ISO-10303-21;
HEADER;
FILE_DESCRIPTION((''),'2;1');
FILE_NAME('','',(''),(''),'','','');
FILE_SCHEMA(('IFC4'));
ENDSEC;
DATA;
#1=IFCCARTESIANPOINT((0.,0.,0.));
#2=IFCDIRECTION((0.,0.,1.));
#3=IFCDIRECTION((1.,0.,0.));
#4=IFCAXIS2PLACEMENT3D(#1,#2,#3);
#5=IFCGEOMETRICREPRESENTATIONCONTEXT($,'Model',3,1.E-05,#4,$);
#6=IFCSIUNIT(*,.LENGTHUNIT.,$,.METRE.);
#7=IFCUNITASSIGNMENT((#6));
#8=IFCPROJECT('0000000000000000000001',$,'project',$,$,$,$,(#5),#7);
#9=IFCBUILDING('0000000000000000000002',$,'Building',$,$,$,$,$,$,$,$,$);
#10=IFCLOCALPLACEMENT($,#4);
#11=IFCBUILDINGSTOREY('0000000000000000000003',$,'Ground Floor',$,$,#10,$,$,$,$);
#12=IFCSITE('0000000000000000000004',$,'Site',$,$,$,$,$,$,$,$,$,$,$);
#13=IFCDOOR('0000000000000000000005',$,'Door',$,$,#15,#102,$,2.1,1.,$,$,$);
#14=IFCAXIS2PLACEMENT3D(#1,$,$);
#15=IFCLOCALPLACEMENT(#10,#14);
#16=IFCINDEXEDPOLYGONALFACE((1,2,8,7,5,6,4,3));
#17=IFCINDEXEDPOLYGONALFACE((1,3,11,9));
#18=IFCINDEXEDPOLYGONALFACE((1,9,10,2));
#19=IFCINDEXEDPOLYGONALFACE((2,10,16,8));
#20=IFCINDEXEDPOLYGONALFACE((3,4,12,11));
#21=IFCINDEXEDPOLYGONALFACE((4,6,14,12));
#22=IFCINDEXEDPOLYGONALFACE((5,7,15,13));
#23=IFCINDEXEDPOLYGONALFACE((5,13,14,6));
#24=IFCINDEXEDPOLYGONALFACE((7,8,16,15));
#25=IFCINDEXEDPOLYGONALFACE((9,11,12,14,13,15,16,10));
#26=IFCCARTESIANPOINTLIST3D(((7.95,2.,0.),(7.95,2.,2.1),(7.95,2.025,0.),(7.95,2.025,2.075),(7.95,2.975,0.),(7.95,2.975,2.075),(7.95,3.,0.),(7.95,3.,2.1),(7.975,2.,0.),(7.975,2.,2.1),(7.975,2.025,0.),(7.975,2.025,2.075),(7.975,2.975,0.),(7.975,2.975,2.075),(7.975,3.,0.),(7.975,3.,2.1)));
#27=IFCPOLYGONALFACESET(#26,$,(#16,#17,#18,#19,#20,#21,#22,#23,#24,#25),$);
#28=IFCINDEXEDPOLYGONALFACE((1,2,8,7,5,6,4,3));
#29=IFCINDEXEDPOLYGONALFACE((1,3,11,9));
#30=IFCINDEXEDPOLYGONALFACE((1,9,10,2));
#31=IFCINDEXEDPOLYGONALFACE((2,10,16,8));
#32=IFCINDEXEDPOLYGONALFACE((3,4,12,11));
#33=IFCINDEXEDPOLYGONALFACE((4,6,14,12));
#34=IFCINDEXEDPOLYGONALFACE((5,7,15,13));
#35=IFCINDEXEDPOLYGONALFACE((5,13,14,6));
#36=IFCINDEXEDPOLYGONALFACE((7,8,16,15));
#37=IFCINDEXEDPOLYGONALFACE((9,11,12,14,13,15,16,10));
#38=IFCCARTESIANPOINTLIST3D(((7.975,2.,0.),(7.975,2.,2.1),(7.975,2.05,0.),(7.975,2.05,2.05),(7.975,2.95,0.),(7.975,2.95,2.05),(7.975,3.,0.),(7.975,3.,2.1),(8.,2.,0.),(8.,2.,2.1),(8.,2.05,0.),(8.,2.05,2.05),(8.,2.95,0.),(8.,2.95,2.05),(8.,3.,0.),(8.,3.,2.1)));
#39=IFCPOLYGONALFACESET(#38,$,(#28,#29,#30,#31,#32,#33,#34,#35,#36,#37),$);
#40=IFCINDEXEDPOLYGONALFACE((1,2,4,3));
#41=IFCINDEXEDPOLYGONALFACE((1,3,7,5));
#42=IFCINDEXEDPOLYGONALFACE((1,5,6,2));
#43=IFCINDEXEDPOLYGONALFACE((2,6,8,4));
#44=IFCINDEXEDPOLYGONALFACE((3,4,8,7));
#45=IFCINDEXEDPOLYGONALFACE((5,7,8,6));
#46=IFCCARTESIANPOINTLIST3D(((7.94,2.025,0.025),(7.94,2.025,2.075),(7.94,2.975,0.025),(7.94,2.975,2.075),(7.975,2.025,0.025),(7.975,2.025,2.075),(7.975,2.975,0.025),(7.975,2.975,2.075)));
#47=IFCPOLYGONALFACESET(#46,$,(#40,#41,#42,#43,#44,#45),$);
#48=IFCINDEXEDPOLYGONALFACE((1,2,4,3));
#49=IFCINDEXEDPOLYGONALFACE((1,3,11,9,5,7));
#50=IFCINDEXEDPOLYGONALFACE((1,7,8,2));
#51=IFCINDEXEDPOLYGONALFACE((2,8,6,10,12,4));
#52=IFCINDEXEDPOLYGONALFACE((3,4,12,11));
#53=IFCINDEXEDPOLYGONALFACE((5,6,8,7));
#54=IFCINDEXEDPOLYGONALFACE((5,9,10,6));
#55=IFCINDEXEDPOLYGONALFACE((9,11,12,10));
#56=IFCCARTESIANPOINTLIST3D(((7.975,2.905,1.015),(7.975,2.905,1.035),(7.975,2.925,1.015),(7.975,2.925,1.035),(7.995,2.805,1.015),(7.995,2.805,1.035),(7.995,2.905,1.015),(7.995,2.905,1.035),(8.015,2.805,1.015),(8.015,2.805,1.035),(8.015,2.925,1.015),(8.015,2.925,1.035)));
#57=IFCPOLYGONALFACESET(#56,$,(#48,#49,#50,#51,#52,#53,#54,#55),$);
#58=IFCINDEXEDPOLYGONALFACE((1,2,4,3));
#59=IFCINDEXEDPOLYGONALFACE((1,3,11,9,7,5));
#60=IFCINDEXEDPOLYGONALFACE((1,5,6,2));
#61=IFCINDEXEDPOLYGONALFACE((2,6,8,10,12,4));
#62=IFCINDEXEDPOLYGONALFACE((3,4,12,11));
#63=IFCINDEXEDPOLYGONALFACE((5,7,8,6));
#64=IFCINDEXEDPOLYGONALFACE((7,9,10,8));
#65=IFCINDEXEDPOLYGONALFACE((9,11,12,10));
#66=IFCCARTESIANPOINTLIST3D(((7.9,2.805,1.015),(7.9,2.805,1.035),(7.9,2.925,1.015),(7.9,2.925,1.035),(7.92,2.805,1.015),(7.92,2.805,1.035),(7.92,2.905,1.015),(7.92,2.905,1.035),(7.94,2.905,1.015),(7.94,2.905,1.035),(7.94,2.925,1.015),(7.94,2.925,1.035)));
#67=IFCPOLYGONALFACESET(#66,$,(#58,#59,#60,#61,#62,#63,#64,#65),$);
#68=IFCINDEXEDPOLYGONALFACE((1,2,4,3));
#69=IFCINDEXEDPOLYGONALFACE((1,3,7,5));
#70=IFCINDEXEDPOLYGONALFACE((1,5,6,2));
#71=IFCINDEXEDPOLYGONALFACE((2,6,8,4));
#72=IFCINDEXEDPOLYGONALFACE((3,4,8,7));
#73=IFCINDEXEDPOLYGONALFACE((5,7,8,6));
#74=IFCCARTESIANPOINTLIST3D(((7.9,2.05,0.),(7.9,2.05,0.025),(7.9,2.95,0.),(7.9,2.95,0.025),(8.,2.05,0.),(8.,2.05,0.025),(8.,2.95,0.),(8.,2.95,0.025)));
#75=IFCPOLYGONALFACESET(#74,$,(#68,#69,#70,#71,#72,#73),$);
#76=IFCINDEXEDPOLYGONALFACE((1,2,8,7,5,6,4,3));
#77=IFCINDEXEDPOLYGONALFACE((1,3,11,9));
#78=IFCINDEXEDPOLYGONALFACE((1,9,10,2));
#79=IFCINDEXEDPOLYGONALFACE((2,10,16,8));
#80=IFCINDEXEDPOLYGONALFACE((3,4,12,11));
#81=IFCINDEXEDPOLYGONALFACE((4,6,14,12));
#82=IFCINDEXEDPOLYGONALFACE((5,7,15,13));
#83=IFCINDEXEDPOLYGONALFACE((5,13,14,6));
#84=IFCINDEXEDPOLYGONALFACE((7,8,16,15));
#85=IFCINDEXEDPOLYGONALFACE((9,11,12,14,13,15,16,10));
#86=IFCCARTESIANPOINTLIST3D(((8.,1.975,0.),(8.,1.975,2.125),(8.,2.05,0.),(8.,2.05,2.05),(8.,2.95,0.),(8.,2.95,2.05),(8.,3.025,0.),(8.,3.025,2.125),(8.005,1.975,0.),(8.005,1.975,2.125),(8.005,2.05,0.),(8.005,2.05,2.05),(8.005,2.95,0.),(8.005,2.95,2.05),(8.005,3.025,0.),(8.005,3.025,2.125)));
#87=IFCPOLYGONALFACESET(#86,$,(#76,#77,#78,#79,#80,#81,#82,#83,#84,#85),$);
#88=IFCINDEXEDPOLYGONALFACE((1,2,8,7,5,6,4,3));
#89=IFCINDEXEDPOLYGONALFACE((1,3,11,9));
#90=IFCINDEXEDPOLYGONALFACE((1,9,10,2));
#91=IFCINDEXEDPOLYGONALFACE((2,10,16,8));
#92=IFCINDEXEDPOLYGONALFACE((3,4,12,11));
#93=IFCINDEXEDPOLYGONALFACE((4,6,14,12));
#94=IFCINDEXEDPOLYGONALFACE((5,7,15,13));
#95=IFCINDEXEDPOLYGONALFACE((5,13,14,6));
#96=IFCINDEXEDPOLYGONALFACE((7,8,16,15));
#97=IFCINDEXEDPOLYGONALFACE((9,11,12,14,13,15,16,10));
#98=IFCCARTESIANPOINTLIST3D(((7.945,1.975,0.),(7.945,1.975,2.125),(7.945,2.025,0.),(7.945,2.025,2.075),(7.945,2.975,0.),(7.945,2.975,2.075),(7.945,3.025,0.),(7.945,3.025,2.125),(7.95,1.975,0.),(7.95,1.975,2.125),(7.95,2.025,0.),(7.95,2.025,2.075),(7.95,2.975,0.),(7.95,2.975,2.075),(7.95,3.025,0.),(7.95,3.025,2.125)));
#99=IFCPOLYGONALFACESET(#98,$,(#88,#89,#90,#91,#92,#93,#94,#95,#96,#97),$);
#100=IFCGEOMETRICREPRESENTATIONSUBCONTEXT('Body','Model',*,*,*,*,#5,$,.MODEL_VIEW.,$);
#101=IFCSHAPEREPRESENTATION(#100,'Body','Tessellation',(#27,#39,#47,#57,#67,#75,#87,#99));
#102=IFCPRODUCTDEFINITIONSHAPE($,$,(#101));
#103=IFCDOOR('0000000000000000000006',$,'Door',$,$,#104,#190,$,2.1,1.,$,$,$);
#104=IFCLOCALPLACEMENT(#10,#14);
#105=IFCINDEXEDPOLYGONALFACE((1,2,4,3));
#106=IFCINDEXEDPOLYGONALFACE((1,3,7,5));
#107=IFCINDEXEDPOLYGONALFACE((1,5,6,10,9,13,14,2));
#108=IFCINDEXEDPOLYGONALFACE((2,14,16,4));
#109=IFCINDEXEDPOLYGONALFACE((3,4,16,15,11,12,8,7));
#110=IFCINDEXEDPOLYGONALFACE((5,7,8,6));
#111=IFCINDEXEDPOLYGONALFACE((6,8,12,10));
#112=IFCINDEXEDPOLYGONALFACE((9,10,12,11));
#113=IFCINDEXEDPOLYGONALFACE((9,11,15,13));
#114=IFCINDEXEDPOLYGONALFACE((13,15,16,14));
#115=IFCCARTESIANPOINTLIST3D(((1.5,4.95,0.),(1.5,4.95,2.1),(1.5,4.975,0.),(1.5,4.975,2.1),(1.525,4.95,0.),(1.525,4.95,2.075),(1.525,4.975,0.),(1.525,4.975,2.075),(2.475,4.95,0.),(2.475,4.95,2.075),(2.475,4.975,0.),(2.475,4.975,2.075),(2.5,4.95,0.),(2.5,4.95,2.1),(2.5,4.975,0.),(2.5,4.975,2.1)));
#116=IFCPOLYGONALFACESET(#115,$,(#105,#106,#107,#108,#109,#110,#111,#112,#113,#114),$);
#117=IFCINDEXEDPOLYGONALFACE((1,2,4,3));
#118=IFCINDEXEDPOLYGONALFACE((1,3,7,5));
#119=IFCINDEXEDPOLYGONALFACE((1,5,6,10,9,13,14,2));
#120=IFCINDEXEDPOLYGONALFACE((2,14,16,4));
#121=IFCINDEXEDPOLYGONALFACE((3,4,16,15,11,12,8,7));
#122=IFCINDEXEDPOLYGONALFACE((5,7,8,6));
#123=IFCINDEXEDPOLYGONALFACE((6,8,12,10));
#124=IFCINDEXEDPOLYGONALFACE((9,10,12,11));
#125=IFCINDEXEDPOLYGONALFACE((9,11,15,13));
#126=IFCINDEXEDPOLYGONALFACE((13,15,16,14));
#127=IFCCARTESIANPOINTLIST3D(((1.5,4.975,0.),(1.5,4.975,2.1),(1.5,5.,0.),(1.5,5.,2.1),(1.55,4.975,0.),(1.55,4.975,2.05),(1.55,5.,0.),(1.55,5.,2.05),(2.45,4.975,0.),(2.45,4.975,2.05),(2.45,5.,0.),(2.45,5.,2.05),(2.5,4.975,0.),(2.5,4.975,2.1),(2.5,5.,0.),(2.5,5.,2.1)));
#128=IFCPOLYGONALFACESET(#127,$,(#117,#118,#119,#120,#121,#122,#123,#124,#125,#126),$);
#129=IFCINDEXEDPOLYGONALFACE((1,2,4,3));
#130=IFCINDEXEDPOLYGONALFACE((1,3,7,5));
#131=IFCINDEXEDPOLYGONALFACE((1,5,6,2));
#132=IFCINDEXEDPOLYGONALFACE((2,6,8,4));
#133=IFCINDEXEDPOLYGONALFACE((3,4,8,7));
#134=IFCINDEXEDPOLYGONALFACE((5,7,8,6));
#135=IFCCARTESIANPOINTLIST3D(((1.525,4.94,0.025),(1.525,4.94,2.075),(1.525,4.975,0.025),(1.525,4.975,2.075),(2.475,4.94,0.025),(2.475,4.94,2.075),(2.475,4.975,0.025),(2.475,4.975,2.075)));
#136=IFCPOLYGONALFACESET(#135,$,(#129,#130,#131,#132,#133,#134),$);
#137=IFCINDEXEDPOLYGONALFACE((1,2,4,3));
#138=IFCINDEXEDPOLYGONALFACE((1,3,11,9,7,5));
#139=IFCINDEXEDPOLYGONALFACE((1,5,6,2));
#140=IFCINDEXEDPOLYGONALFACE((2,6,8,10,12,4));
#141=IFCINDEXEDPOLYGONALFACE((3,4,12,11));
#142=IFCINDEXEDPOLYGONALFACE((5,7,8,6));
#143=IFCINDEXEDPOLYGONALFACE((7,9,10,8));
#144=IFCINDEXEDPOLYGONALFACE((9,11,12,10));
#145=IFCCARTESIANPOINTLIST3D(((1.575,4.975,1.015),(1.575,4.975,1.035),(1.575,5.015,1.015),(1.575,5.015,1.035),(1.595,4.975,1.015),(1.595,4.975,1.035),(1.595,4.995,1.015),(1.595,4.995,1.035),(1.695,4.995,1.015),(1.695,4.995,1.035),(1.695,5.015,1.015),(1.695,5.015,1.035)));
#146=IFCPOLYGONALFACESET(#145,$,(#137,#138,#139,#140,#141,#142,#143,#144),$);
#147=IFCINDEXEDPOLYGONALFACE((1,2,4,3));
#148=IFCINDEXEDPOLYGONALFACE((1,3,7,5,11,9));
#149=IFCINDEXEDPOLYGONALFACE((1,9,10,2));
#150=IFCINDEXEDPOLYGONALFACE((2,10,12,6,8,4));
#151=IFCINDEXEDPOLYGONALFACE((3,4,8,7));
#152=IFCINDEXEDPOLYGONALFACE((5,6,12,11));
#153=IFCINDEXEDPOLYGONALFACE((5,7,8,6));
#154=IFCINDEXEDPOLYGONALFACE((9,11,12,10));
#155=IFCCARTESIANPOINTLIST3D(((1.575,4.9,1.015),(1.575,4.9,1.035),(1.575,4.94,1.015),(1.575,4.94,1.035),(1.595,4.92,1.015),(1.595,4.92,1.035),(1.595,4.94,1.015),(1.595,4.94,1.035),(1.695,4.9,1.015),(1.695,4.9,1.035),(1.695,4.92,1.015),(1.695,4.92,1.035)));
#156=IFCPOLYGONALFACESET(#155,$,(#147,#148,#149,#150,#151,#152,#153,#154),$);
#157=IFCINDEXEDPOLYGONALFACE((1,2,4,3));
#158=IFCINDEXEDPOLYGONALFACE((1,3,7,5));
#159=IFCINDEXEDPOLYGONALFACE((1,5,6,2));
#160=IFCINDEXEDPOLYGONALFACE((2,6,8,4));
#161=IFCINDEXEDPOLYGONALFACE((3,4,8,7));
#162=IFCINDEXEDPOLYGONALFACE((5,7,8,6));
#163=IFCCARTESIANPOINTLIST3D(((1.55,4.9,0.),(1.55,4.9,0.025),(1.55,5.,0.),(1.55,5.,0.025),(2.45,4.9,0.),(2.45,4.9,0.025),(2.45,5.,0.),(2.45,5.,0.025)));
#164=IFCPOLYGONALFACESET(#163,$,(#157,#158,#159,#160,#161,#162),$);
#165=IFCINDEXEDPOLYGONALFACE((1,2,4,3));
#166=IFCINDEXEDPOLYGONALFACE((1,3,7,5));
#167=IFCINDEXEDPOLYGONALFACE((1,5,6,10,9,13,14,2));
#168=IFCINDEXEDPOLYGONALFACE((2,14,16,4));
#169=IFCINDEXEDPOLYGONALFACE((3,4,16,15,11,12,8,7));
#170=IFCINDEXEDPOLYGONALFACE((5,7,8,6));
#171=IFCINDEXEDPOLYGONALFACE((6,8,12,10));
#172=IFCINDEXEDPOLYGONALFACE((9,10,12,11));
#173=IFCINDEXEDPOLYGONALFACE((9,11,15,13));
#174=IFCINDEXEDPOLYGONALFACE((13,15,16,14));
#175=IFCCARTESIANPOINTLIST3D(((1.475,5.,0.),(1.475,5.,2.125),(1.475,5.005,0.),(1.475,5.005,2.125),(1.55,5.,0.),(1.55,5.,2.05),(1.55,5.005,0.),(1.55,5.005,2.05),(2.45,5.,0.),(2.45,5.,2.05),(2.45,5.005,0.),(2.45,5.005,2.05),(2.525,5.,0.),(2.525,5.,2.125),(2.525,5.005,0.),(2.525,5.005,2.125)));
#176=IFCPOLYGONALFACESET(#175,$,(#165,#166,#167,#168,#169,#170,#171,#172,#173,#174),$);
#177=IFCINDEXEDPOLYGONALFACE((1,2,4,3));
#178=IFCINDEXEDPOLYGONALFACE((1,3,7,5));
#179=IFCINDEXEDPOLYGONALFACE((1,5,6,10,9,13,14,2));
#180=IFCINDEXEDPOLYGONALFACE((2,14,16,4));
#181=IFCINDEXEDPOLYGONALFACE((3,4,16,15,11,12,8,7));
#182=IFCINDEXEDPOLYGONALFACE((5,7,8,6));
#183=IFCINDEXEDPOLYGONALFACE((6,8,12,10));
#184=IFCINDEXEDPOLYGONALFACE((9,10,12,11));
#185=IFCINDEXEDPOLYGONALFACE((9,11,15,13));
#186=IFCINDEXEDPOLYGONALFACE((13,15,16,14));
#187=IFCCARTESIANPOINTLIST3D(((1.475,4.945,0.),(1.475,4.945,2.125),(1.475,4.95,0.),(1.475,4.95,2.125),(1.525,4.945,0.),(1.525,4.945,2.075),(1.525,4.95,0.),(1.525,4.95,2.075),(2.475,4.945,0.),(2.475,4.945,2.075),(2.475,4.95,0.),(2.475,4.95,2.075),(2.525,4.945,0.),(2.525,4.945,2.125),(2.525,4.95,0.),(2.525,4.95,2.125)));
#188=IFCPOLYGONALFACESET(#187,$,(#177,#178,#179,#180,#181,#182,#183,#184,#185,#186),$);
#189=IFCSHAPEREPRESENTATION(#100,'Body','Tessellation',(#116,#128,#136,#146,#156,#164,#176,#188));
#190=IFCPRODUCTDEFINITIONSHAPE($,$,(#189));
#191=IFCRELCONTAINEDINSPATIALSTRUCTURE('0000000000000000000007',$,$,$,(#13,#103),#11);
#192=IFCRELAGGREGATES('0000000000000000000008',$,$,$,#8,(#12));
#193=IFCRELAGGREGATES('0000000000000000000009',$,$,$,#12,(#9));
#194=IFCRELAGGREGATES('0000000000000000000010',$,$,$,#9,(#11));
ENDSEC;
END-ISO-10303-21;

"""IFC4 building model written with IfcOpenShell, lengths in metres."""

from ifc_helpers import new_model, si_unit, frame, origin_with_axes, place, context, subcontext, project, spatial, line, indexed_curve, outline, extrude, element, save


model = new_model("IFC4")

# Units and contexts
model_context = context("Model", 3, precision=1e-05, world=origin_with_axes())
body_context = subcontext(model_context, "Body", "Model", "MODEL_VIEW")
ifc_project = project(units=[si_unit("LENGTHUNIT", "METRE")], contexts=[model_context])

# Site, building, storey
site = spatial("IfcSite", under=ifc_project, Name="Site")
building = spatial("IfcBuilding", under=site, Name="Building")
storey_placement = place(None, origin_with_axes())
storey = spatial("IfcBuildingStorey", under=building, at=storey_placement, Name="Ground Floor")

# Doors
door_1_placement = place(storey_placement, frame((8.0, 2.0, 0.0), z_axis=(0.0, 0.0, 1.0), x_axis=(0.0, 1.0, 0.0)))
element("IfcDoor", 1, at=door_1_placement, inside=storey, Name="Door", OverallHeight=2.1, OverallWidth=1.0, context=body_context, shape_type="SweptSolid", body=[
    extrude(outline(indexed_curve([(0.0, 0.0), (0.0, 2.1), (1.0, 2.1), (1.0, 0.0), (0.975, 0.0), (0.975, 2.075), (0.025, 2.075), (0.025, 0.0)], segments=[line(1, 2, 3, 4, 5, 6, 7, 8, 1)])), frame((0.0, 0.025, 0.0), z_axis=(0.0, -1.0, 0.0), x_axis=(1.0, 0.0, 0.0)), (0.0, 0.0, -1.0), 0.025),
    extrude(outline(indexed_curve([(0.0, 0.0), (0.0, 2.1), (1.0, 2.1), (1.0, 0.0), (0.95, 0.0), (0.95, 2.05), (0.05, 2.05), (0.05, 0.0)], segments=[line(1, 2, 3, 4, 5, 6, 7, 8, 1)])), frame((0.0, 0.0, 0.0), z_axis=(0.0, -1.0, 0.0), x_axis=(1.0, 0.0, 0.0)), (0.0, 0.0, -1.0), 0.025),
    extrude(outline(indexed_curve([(0.0, 0.0), (0.95, 0.0), (0.95, 0.035), (0.0, 0.035)], segments=[line(1, 2, 3, 4, 1)])), frame((0.025, 0.025, 0.025), z_axis=(0.0, 0.0, 1.0), x_axis=(1.0, 0.0, 0.0)), (0.0, 0.0, 1.0), 2.05),
    extrude(outline(indexed_curve([(0.0, 0.0), (0.0, -0.04), (-0.12, -0.04), (-0.12, -0.02), (-0.02, -0.02), (-0.02, 0.0)], segments=[line(1, 2, 3, 4, 5, 6, 1)])), frame((0.925, 0.025, 1.015), z_axis=(0.0, 0.0, 1.0), x_axis=(1.0, 0.0, 0.0)), (0.0, 0.0, 1.0), 0.02),
    extrude(outline(indexed_curve([(0.0, 0.0), (0.0, 0.04), (-0.12, 0.04), (-0.12, 0.02), (-0.02, 0.02), (-0.02, 0.0)], segments=[line(1, 2, 3, 4, 5, 6, 1)])), frame((0.925, 0.06, 1.015), z_axis=(0.0, 0.0, 1.0), x_axis=(1.0, 0.0, 0.0)), (0.0, 0.0, 1.0), 0.02),
    extrude(outline(indexed_curve([(0.0, 0.0), (0.9, 0.0), (0.9, 0.1), (0.0, 0.1)], segments=[line(1, 2, 3, 4, 1)])), frame((0.05, 0.0, 0.0), z_axis=(0.0, 0.0, 1.0), x_axis=(1.0, 0.0, 0.0)), (0.0, 0.0, 1.0), 0.025),
    extrude(outline(indexed_curve([(0.0, 0.0), (0.0, 2.125), (1.05, 2.125), (1.05, 0.0), (0.975, 0.0), (0.975, 2.05), (0.075, 2.05), (0.075, 0.0)], segments=[line(1, 2, 3, 4, 5, 6, 7, 8, 1)])), frame((-0.025, -0.005, 0.0), z_axis=(0.0, -1.0, 0.0), x_axis=(1.0, 0.0, 0.0)), (0.0, 0.0, -1.0), 0.005),
    extrude(outline(indexed_curve([(0.0, 0.0), (0.0, 2.125), (1.05, 2.125), (1.05, 0.0), (1.0, 0.0), (1.0, 2.075), (0.05, 2.075), (0.05, 0.0)], segments=[line(1, 2, 3, 4, 5, 6, 7, 8, 1)])), frame((-0.025, 0.05, 0.0), z_axis=(0.0, -1.0, 0.0), x_axis=(1.0, 0.0, 0.0)), (0.0, 0.0, -1.0), 0.005),
])
door_2_placement = place(storey_placement, frame((2.5, 5.0, 0.0), z_axis=(0.0, 0.0, 1.0), x_axis=(-1.0, 0.0, 0.0)))
element("IfcDoor", 2, at=door_2_placement, inside=storey, Name="Door", OverallHeight=2.1, OverallWidth=1.0, context=body_context, shape_type="SweptSolid", body=[
    extrude(outline(indexed_curve([(0.0, 0.0), (0.0, 2.1), (1.0, 2.1), (1.0, 0.0), (0.975, 0.0), (0.975, 2.075), (0.025, 2.075), (0.025, 0.0)], segments=[line(1, 2, 3, 4, 5, 6, 7, 8, 1)])), frame((0.0, 0.025, 0.0), z_axis=(0.0, -1.0, 0.0), x_axis=(1.0, 0.0, 0.0)), (0.0, 0.0, -1.0), 0.025),
    extrude(outline(indexed_curve([(0.0, 0.0), (0.0, 2.1), (1.0, 2.1), (1.0, 0.0), (0.95, 0.0), (0.95, 2.05), (0.05, 2.05), (0.05, 0.0)], segments=[line(1, 2, 3, 4, 5, 6, 7, 8, 1)])), frame((0.0, 0.0, 0.0), z_axis=(0.0, -1.0, 0.0), x_axis=(1.0, 0.0, 0.0)), (0.0, 0.0, -1.0), 0.025),
    extrude(outline(indexed_curve([(0.0, 0.0), (0.95, 0.0), (0.95, 0.035), (0.0, 0.035)], segments=[line(1, 2, 3, 4, 1)])), frame((0.025, 0.025, 0.025), z_axis=(0.0, 0.0, 1.0), x_axis=(1.0, 0.0, 0.0)), (0.0, 0.0, 1.0), 2.05),
    extrude(outline(indexed_curve([(0.0, 0.0), (0.0, -0.04), (-0.12, -0.04), (-0.12, -0.02), (-0.02, -0.02), (-0.02, 0.0)], segments=[line(1, 2, 3, 4, 5, 6, 1)])), frame((0.925, 0.025, 1.015), z_axis=(0.0, 0.0, 1.0), x_axis=(1.0, 0.0, 0.0)), (0.0, 0.0, 1.0), 0.02),
    extrude(outline(indexed_curve([(0.0, 0.0), (0.0, 0.04), (-0.12, 0.04), (-0.12, 0.02), (-0.02, 0.02), (-0.02, 0.0)], segments=[line(1, 2, 3, 4, 5, 6, 1)])), frame((0.925, 0.06, 1.015), z_axis=(0.0, 0.0, 1.0), x_axis=(1.0, 0.0, 0.0)), (0.0, 0.0, 1.0), 0.02),
    extrude(outline(indexed_curve([(0.0, 0.0), (0.9, 0.0), (0.9, 0.1), (0.0, 0.1)], segments=[line(1, 2, 3, 4, 1)])), frame((0.05, 0.0, 0.0), z_axis=(0.0, 0.0, 1.0), x_axis=(1.0, 0.0, 0.0)), (0.0, 0.0, 1.0), 0.025),
    extrude(outline(indexed_curve([(0.0, 0.0), (0.0, 2.125), (1.05, 2.125), (1.05, 0.0), (0.975, 0.0), (0.975, 2.05), (0.075, 2.05), (0.075, 0.0)], segments=[line(1, 2, 3, 4, 5, 6, 7, 8, 1)])), frame((-0.025, -0.005, 0.0), z_axis=(0.0, -1.0, 0.0), x_axis=(1.0, 0.0, 0.0)), (0.0, 0.0, -1.0), 0.005),
    extrude(outline(indexed_curve([(0.0, 0.0), (0.0, 2.125), (1.05, 2.125), (1.05, 0.0), (1.0, 0.0), (1.0, 2.075), (0.05, 2.075), (0.05, 0.0)], segments=[line(1, 2, 3, 4, 5, 6, 7, 8, 1)])), frame((-0.025, 0.05, 0.0), z_axis=(0.0, -1.0, 0.0), x_axis=(1.0, 0.0, 0.0)), (0.0, 0.0, -1.0), 0.005),
])

save(model, "model.ifc")
